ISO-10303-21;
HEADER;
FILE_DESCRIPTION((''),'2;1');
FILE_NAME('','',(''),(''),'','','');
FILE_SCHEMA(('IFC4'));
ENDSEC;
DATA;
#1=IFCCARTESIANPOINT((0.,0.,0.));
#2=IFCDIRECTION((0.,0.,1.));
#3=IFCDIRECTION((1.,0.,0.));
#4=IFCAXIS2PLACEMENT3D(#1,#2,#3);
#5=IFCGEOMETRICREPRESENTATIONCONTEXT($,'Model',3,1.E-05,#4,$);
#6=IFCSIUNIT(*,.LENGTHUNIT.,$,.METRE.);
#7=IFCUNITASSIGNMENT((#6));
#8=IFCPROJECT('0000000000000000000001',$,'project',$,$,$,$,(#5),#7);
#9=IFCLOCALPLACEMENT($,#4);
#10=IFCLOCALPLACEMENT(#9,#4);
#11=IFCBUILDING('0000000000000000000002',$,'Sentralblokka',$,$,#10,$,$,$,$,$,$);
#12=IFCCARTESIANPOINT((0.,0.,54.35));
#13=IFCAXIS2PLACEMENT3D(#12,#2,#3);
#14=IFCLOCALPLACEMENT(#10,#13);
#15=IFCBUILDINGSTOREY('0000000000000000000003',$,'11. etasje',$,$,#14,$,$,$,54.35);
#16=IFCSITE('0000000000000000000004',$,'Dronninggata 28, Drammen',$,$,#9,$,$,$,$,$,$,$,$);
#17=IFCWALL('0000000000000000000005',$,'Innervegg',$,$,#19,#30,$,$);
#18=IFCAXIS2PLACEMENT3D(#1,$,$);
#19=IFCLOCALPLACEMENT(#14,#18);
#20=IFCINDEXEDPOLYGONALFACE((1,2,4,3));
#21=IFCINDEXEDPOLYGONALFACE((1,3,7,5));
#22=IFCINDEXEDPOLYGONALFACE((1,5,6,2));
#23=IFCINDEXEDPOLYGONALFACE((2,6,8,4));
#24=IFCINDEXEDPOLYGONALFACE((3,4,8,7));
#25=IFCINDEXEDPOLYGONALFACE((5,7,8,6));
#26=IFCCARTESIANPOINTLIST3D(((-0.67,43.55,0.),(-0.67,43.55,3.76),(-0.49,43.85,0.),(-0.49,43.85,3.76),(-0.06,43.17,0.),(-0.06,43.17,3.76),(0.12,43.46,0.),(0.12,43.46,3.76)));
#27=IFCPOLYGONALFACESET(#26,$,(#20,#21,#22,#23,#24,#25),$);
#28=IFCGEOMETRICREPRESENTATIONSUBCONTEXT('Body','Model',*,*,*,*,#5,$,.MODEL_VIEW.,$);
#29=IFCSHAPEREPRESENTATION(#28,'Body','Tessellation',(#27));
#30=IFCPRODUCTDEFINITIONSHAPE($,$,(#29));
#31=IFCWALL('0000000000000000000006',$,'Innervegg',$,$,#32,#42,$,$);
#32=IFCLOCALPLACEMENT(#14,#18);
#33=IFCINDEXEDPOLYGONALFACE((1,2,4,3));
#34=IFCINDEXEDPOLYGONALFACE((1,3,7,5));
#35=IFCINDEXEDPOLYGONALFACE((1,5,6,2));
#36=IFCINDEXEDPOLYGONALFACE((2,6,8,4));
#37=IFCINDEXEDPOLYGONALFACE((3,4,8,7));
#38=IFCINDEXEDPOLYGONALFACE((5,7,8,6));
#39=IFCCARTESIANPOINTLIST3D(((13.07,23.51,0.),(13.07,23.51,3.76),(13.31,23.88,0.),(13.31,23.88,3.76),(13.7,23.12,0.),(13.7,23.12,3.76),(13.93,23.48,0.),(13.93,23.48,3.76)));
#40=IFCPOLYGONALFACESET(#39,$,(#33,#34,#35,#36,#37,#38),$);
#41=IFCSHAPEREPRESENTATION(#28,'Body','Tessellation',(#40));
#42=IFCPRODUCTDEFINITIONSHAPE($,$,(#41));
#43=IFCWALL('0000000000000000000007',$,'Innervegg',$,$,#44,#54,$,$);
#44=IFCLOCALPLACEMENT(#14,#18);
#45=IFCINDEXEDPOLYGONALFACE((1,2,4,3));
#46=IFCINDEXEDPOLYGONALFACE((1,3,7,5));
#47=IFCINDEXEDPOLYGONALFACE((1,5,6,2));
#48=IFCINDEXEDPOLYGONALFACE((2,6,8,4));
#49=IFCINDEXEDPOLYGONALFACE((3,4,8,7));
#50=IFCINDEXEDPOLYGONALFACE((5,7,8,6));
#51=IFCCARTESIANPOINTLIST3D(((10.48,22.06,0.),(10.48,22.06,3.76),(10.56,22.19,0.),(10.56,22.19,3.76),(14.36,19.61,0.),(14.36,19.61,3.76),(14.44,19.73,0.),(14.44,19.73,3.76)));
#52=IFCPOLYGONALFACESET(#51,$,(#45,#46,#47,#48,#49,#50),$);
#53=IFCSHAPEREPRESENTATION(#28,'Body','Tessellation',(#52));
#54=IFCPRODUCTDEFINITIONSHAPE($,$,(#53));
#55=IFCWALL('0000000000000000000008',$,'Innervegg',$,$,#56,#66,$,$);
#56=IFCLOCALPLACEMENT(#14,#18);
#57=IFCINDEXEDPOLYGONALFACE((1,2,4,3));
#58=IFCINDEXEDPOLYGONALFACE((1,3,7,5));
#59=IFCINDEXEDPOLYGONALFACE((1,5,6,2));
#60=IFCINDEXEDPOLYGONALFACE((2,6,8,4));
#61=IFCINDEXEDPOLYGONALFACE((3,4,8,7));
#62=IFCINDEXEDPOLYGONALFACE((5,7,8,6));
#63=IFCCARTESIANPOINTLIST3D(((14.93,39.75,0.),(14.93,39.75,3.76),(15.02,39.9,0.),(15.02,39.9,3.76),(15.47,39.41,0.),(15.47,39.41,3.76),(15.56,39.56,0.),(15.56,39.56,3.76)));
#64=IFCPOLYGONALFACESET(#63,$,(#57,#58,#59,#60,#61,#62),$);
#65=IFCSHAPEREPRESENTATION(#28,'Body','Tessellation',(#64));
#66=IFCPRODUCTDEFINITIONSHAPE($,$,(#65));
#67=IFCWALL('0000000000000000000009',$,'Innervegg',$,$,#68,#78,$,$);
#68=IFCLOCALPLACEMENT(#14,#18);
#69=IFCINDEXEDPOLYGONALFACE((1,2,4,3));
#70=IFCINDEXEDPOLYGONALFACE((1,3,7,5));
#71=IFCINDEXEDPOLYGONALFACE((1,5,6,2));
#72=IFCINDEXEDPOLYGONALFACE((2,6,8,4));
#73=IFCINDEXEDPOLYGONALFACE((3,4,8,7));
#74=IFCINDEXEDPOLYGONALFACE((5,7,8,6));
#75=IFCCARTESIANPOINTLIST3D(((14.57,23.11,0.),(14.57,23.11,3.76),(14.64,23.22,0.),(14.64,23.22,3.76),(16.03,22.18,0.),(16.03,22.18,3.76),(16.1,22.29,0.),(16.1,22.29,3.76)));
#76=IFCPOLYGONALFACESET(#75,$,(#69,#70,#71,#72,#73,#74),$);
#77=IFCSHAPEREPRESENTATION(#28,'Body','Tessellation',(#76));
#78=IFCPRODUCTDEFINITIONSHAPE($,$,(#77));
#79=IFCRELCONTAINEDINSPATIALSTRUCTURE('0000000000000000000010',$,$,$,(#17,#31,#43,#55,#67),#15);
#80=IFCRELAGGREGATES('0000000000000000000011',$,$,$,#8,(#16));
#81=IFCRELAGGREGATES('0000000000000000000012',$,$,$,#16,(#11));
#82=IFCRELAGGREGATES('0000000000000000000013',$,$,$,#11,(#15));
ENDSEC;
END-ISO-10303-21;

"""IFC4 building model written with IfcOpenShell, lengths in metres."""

from ifc_helpers import new_model, si_unit, frame, origin_with_axes, place, context, subcontext, project, spatial, polyline, outline, extrude, element, save


model = new_model("IFC4")

# Units and contexts
model_context = context("Model", 3, precision=1e-05, world=origin_with_axes())
body_context = subcontext(model_context, "Body", "Model", "MODEL_VIEW")
ifc_project = project(units=[si_unit("LENGTHUNIT", "METRE")], contexts=[model_context])

# Site, building, storey
site_placement = place(None, origin_with_axes())
site = spatial("IfcSite", under=ifc_project, at=site_placement, Name="Dronninggata 28, Drammen")
building_placement = place(site_placement, origin_with_axes())
building = spatial("IfcBuilding", under=site, at=building_placement, Name="Sentralblokka")
storey_placement = place(building_placement, frame((0.0, 0.0, 54.35), z_axis=(0.0, 0.0, 1.0), x_axis=(1.0, 0.0, 0.0)))
storey = spatial("IfcBuildingStorey", under=building, at=storey_placement, Name="11. etasje", Elevation=54.35)

# Walls
wall_1_placement = place(storey_placement, frame((0.0, 0.0, -54.35), z_axis=(0.0, 0.0, 1.0), x_axis=(1.0, 0.0, 0.0)))
element("IfcWall", 1, at=wall_1_placement, inside=storey, Name="Innervegg", context=body_context, shape_type="SweptSolid", body=[
    extrude(outline(polyline([(0.12, 43.46), (-0.06, 43.17), (-0.67, 43.55), (-0.49, 43.85), (0.12, 43.46)])), frame((0.0, 0.0, 54.35)), (0.0, 0.0, 1.0), 3.76),
])
wall_2_placement = place(storey_placement, frame((0.0, 0.0, -54.35), z_axis=(0.0, 0.0, 1.0), x_axis=(1.0, 0.0, 0.0)))
element("IfcWall", 2, at=wall_2_placement, inside=storey, Name="Innervegg", context=body_context, shape_type="SweptSolid", body=[
    extrude(outline(polyline([(13.93, 23.48), (13.7, 23.12), (13.07, 23.51), (13.31, 23.88), (13.93, 23.48)])), frame((0.0, 0.0, 54.35)), (0.0, 0.0, 1.0), 3.76),
])
wall_3_placement = place(storey_placement, frame((0.0, 0.0, -54.35), z_axis=(0.0, 0.0, 1.0), x_axis=(1.0, 0.0, 0.0)))
element("IfcWall", 3, at=wall_3_placement, inside=storey, Name="Innervegg", context=body_context, shape_type="SweptSolid", body=[
    extrude(outline(polyline([(14.44, 19.73), (14.36, 19.61), (10.48, 22.06), (10.56, 22.19), (14.44, 19.73)])), frame((0.0, 0.0, 54.35)), (0.0, 0.0, 1.0), 3.76),
])
wall_4_placement = place(storey_placement, frame((0.0, 0.0, -54.35), z_axis=(0.0, 0.0, 1.0), x_axis=(1.0, 0.0, 0.0)))
element("IfcWall", 4, at=wall_4_placement, inside=storey, Name="Innervegg", context=body_context, shape_type="SweptSolid", body=[
    extrude(outline(polyline([(15.56, 39.56), (15.47, 39.41), (14.93, 39.75), (15.02, 39.9), (15.56, 39.56)])), frame((0.0, 0.0, 54.35)), (0.0, 0.0, 1.0), 3.76),
])
wall_5_placement = place(storey_placement, frame((0.0, 0.0, -54.35), z_axis=(0.0, 0.0, 1.0), x_axis=(1.0, 0.0, 0.0)))
element("IfcWall", 5, at=wall_5_placement, inside=storey, Name="Innervegg", context=body_context, shape_type="SweptSolid", body=[
    extrude(outline(polyline([(16.1, 22.29), (16.03, 22.18), (14.57, 23.11), (14.64, 23.22), (16.1, 22.29)])), frame((0.0, 0.0, 54.35)), (0.0, 0.0, 1.0), 3.76),
])

save(model, "model.ifc")
